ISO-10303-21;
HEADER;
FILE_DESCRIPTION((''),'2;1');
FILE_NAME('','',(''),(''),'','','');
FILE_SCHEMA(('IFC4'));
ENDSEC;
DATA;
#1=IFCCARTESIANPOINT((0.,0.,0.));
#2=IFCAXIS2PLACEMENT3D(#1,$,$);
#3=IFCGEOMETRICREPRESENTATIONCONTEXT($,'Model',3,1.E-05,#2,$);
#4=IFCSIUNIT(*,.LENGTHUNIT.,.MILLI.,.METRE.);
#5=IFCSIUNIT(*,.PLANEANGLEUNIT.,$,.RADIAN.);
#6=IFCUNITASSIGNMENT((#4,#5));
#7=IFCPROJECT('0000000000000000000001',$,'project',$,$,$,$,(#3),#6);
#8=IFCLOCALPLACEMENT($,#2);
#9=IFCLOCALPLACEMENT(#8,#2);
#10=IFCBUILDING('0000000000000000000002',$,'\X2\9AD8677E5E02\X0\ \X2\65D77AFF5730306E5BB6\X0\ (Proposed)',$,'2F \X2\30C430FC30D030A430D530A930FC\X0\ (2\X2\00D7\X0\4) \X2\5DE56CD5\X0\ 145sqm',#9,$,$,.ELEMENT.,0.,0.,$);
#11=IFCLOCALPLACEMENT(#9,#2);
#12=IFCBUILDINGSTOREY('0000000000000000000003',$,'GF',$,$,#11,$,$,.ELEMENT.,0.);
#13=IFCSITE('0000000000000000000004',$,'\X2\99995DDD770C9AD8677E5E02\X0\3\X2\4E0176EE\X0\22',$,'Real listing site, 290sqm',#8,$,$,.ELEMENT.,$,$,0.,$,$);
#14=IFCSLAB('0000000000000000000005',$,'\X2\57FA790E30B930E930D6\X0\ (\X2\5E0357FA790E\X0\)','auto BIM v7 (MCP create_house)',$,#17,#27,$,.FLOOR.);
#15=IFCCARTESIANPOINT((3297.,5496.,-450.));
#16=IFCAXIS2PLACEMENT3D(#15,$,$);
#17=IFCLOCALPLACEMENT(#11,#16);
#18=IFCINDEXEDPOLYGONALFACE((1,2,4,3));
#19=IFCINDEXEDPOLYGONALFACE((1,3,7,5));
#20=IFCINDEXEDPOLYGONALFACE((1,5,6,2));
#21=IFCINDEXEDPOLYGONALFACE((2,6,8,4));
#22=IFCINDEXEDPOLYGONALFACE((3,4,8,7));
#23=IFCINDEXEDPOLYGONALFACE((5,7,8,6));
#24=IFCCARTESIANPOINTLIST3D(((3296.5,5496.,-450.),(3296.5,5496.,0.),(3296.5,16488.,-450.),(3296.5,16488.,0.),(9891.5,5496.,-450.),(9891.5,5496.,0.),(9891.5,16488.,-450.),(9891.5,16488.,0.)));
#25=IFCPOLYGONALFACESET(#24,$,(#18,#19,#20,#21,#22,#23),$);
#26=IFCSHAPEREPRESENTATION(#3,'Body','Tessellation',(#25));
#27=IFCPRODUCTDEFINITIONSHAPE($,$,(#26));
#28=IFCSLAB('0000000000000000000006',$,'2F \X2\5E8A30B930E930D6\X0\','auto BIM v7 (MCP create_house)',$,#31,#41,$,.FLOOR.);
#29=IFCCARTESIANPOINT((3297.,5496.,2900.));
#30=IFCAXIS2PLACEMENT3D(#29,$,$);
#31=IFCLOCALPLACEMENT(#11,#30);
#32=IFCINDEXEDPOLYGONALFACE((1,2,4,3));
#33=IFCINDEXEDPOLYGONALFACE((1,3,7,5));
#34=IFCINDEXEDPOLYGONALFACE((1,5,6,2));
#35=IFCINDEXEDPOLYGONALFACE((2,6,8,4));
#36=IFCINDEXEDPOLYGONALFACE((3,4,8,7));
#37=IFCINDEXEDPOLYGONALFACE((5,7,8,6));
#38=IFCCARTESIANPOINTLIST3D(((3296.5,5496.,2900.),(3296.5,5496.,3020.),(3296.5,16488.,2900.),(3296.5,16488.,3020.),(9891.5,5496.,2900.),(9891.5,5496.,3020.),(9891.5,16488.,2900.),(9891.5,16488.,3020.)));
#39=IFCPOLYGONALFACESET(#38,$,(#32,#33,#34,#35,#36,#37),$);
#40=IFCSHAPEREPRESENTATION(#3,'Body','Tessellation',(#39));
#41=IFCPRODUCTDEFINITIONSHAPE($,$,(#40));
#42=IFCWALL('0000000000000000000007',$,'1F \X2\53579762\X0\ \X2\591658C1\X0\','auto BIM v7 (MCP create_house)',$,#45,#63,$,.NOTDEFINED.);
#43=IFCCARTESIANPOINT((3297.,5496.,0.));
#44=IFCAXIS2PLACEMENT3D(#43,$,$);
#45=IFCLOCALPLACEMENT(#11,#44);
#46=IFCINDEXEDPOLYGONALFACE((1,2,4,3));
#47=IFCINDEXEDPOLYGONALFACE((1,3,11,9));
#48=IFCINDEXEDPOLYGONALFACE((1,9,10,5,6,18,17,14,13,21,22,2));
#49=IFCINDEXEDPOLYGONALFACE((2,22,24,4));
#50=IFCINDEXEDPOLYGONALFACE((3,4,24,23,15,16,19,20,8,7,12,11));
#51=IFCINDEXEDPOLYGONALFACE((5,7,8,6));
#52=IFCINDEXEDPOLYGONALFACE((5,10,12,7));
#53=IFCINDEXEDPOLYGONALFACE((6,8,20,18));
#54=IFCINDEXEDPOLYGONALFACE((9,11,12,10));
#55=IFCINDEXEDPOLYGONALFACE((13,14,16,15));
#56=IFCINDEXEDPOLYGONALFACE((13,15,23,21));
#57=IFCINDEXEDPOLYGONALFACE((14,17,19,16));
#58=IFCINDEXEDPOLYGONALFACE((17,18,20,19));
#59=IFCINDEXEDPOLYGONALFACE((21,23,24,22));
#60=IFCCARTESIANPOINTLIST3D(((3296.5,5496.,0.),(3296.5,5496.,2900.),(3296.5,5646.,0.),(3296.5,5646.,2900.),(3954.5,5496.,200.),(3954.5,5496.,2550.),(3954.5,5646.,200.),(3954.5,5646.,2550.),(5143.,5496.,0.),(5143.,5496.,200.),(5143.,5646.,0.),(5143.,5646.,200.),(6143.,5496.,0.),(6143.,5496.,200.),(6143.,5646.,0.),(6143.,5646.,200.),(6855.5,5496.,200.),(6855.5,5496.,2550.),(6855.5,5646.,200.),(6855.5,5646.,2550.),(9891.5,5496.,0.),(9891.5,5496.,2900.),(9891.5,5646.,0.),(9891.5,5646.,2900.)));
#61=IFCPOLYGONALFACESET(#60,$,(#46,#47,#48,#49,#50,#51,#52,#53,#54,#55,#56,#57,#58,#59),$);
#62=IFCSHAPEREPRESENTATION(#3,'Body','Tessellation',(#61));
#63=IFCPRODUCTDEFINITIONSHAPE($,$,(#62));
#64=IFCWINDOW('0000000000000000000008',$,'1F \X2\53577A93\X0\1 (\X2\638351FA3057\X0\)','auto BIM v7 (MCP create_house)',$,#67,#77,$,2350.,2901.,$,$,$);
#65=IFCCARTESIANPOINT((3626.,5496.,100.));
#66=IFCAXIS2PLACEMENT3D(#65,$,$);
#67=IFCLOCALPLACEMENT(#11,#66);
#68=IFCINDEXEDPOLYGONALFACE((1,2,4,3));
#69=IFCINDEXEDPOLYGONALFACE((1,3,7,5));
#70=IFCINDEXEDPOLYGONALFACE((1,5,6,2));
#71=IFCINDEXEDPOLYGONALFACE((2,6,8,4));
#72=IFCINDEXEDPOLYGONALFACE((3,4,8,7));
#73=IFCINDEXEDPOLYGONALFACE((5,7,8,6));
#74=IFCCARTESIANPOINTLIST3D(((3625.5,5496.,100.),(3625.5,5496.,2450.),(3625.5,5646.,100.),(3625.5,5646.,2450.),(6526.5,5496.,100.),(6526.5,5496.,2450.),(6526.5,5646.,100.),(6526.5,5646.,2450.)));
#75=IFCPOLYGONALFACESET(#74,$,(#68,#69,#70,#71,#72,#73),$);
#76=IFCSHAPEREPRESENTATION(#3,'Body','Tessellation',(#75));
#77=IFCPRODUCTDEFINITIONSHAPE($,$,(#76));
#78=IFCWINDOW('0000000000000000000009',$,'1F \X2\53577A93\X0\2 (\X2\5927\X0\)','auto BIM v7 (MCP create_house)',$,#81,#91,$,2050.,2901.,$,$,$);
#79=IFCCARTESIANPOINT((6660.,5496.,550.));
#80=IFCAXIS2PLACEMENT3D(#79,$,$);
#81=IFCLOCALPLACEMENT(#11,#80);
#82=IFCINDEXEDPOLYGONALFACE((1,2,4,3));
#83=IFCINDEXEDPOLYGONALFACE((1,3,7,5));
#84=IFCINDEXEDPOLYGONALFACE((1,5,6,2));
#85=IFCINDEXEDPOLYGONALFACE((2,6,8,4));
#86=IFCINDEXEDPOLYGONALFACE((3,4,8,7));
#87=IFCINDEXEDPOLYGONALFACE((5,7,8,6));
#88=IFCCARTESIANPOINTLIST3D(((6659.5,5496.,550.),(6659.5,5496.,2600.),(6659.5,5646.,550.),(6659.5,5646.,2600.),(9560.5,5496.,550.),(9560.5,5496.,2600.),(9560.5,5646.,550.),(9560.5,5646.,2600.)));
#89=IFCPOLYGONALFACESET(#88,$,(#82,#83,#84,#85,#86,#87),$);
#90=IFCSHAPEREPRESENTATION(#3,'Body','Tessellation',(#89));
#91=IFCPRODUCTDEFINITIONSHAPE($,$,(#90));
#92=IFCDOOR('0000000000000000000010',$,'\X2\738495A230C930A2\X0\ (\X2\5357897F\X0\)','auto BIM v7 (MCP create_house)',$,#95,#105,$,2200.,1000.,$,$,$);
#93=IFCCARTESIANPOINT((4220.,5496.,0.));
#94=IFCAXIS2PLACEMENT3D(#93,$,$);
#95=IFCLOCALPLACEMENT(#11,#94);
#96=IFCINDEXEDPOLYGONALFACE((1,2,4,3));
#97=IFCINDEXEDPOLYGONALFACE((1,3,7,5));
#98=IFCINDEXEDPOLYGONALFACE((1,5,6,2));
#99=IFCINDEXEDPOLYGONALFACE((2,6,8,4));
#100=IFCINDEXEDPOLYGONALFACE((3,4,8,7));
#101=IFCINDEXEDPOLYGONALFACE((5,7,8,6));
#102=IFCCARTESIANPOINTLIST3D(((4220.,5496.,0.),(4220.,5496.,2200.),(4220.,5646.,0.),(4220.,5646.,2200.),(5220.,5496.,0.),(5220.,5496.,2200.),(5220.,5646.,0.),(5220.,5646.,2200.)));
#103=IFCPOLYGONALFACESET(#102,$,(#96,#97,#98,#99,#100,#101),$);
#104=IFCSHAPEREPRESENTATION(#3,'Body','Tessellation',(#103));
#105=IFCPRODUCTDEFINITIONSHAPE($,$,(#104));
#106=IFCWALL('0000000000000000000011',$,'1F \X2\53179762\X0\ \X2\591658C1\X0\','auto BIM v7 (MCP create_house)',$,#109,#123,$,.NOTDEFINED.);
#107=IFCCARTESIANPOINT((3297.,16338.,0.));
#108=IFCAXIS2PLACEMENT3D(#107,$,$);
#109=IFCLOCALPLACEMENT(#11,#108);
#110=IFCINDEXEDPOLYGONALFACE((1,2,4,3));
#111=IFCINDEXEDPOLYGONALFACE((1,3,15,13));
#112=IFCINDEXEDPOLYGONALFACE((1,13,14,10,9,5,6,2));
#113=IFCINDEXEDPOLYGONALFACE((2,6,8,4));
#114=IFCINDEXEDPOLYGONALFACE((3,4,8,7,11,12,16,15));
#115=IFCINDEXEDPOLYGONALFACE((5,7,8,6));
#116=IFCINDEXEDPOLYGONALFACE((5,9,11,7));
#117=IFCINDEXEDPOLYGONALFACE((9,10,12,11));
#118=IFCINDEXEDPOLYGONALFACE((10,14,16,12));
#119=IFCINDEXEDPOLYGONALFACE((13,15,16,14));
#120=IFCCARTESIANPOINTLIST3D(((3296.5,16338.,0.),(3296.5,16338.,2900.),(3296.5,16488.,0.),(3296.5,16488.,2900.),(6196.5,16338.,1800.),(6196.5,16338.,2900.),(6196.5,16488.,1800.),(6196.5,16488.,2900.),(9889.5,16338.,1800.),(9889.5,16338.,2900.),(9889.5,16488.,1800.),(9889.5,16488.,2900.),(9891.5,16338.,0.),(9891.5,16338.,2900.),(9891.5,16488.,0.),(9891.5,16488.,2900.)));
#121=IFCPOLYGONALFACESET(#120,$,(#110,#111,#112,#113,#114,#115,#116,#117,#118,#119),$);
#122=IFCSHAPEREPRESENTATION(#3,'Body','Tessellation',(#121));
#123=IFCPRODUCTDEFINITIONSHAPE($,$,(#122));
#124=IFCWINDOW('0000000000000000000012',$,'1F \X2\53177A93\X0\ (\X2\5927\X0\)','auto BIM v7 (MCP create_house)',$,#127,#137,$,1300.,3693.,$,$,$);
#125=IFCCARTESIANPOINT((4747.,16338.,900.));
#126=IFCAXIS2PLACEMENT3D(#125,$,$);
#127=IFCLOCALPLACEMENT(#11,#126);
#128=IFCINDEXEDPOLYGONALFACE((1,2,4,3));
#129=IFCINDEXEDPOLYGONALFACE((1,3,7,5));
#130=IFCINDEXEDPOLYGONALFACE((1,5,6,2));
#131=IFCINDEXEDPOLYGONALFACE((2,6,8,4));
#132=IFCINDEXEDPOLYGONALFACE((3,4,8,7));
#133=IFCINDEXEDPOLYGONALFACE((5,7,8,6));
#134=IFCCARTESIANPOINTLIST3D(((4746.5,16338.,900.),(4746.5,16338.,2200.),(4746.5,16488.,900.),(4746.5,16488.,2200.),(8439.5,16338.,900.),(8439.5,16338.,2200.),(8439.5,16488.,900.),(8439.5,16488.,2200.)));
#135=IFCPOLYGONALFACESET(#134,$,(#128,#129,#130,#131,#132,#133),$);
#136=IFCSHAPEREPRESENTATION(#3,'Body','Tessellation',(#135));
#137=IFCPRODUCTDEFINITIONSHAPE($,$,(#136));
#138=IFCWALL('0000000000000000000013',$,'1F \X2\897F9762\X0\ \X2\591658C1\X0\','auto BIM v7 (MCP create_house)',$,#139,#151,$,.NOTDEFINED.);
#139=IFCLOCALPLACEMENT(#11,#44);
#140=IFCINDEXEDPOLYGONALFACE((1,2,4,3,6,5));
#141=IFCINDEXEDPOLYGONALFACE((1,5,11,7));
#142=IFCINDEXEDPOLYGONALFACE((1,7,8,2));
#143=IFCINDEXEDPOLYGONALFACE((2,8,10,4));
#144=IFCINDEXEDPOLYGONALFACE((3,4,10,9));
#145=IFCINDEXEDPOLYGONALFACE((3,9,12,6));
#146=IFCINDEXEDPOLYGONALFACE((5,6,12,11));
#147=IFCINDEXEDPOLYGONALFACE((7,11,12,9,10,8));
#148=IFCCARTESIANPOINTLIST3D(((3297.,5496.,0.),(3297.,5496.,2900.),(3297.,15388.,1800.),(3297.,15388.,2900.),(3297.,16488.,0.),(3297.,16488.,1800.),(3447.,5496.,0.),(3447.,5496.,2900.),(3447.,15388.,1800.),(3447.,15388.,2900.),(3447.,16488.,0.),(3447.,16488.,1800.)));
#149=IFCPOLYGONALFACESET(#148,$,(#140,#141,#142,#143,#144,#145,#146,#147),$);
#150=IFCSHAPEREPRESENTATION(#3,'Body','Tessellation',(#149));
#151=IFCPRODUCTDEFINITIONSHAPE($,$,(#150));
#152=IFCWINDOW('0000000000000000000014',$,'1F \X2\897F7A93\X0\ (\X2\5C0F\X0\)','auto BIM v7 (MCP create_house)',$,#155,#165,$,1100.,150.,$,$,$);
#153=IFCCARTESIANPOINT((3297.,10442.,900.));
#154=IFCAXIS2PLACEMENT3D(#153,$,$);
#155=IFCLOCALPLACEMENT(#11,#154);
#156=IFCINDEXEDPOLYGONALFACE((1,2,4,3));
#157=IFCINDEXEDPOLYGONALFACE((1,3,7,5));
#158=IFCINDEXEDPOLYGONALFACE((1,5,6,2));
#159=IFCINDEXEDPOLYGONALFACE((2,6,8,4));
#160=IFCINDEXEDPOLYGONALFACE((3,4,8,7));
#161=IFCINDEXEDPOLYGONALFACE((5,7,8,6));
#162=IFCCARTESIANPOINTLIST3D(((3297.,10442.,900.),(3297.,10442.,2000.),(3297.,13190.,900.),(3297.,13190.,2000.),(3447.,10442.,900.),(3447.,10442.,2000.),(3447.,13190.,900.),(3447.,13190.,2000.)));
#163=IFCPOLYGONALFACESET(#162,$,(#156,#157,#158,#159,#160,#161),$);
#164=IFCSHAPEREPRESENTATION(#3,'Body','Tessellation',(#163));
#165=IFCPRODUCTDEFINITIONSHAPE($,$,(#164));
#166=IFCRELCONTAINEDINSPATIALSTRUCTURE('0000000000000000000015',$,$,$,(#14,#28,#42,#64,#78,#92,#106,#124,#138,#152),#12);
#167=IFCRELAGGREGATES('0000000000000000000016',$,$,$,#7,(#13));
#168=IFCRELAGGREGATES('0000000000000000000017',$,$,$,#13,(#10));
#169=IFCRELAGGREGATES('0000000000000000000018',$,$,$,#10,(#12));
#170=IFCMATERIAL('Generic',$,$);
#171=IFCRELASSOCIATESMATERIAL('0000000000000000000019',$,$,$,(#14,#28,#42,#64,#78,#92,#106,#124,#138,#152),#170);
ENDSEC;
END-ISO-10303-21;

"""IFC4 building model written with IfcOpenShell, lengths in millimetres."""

from ifc_helpers import new_model, si_unit, frame, frame_2d, origin, place, context, project, spatial, rectangle, extrude, material, element, fill, save


model = new_model("IFC4")

# Units and contexts
model_context = context("Model", 3, precision=1e-05, world=origin())
ifc_project = project(units=[si_unit("LENGTHUNIT", "METRE", prefix="MILLI"), si_unit("PLANEANGLEUNIT", "RADIAN")], contexts=[model_context])

# Site, building, storey
site_placement = place(None, origin())
site = spatial("IfcSite", under=ifc_project, at=site_placement, Name="香川県高松市3丁目22", ObjectType="Real listing site, 290sqm", CompositionType="ELEMENT", RefElevation=0.0)
building_placement = place(site_placement, origin())
building = spatial("IfcBuilding", under=site, at=building_placement, Name="高松市 旗竿地の家 (Proposed)", ObjectType="2F ツーバイフォー (2×4) 工法 145sqm", CompositionType="ELEMENT", ElevationOfRefHeight=0.0, ElevationOfTerrain=0.0)
storey_placement = place(building_placement, origin())
storey = spatial("IfcBuildingStorey", under=building, at=storey_placement, Name="GF", CompositionType="ELEMENT", Elevation=0.0)

# Slabs
ifc_material = material(Name="Generic")
slab_1_placement = place(storey_placement, frame((3297.0, 5496.0, -450.0)))
element("IfcSlab", 1, at=slab_1_placement, inside=storey, material=ifc_material, Name="基礎スラブ (布基礎)", Description="auto BIM v7 (MCP create_house)", PredefinedType="FLOOR", context=model_context, shape_type="SweptSolid", body=[
    extrude(rectangle(XDim=6595.0, YDim=10992.0, at=frame_2d((3297.0, 5496.0))), frame((3297.0, 5496.0, -450.0)), (0.0, 0.0, 1.0), 450.0),
])
slab_2_placement = place(storey_placement, frame((3297.0, 5496.0, 2900.0)))
element("IfcSlab", 2, at=slab_2_placement, inside=storey, material=ifc_material, Name="2F 床スラブ", Description="auto BIM v7 (MCP create_house)", PredefinedType="FLOOR", context=model_context, shape_type="SweptSolid", body=[
    extrude(rectangle(XDim=6595.0, YDim=10992.0, at=frame_2d((3297.0, 5496.0))), frame((3297.0, 5496.0, 2900.0)), (0.0, 0.0, 1.0), 120.0),
])

# Wall, openings, windows, door
wall_1_placement = place(storey_placement, frame((3297.0, 5496.0, 0.0)))
wall_1 = element("IfcWall", 3, at=wall_1_placement, inside=storey, material=ifc_material, Name="1F 南面 外壁", Description="auto BIM v7 (MCP create_house)", PredefinedType="NOTDEFINED", context=model_context, shape_type="SweptSolid", body=[
    extrude(rectangle(XDim=6595.0, YDim=150.0, at=frame_2d((3297.0, 75.0))), frame((3297.0, 5496.0, 0.0)), (0.0, 0.0, 1.0), 2900.0),
])
opening_1_placement = place(storey_placement, frame((3626.0, 5496.0, 100.0)))
opening_1 = element("IfcOpeningElement", 4, at=opening_1_placement, cuts=wall_1, PredefinedType="NOTDEFINED", context=model_context, shape_type="SweptSolid", body=[
    extrude(rectangle(XDim=2901.0, YDim=150.0, at=frame_2d((1450.0, 75.0))), frame((3626.0, 5496.0, 100.0)), (0.0, 0.0, 1.0), 2350.0),
])
opening_2_placement = place(storey_placement, frame((6660.0, 5496.0, 550.0)))
opening_2 = element("IfcOpeningElement", 5, at=opening_2_placement, cuts=wall_1, PredefinedType="NOTDEFINED", context=model_context, shape_type="SweptSolid", body=[
    extrude(rectangle(XDim=2901.0, YDim=150.0, at=frame_2d((1450.0, 75.0))), frame((6660.0, 5496.0, 550.0)), (0.0, 0.0, 1.0), 2050.0),
])
opening_3_placement = place(storey_placement, frame((4220.0, 5496.0, 0.0)))
opening_3 = element("IfcOpeningElement", 6, at=opening_3_placement, cuts=wall_1, PredefinedType="NOTDEFINED", context=model_context, shape_type="SweptSolid", body=[
    extrude(rectangle(XDim=1000.0, YDim=150.0, at=frame_2d((500.0, 75.0))), frame((4220.0, 5496.0, 0.0)), (0.0, 0.0, 1.0), 2200.0),
])
window_1_placement = place(storey_placement, frame((3626.0, 5496.0, 100.0)))
window_1 = element("IfcWindow", 7, at=window_1_placement, inside=storey, material=ifc_material, Name="1F 南窓1 (掃出し)", Description="auto BIM v7 (MCP create_house)", OverallHeight=2350.0, OverallWidth=2901.0, context=model_context, shape_type="SweptSolid", body=[
    extrude(rectangle(XDim=2901.0, YDim=150.0, at=frame_2d((1450.0, 75.0))), frame((3626.0, 5496.0, 100.0)), (0.0, 0.0, 1.0), 2350.0),
])
fill(opening_1, window_1)
window_2_placement = place(storey_placement, frame((6660.0, 5496.0, 550.0)))
window_2 = element("IfcWindow", 8, at=window_2_placement, inside=storey, material=ifc_material, Name="1F 南窓2 (大)", Description="auto BIM v7 (MCP create_house)", OverallHeight=2050.0, OverallWidth=2901.0, context=model_context, shape_type="SweptSolid", body=[
    extrude(rectangle(XDim=2901.0, YDim=150.0, at=frame_2d((1450.0, 75.0))), frame((6660.0, 5496.0, 550.0)), (0.0, 0.0, 1.0), 2050.0),
])
fill(opening_2, window_2)
door_placement = place(storey_placement, frame((4220.0, 5496.0, 0.0)))
door = element("IfcDoor", 9, at=door_placement, inside=storey, material=ifc_material, Name="玄関ドア (南西)", Description="auto BIM v7 (MCP create_house)", OverallHeight=2200.0, OverallWidth=1000.0, context=model_context, shape_type="SweptSolid", body=[
    extrude(rectangle(XDim=1000.0, YDim=150.0, at=frame_2d((500.0, 75.0))), frame((4220.0, 5496.0, 0.0)), (0.0, 0.0, 1.0), 2200.0),
])
fill(opening_3, door)

# Walls, openings, windows
wall_2_placement = place(storey_placement, frame((3297.0, 16338.0, 0.0)))
wall_2 = element("IfcWall", 10, at=wall_2_placement, inside=storey, material=ifc_material, Name="1F 北面 外壁", Description="auto BIM v7 (MCP create_house)", PredefinedType="NOTDEFINED", context=model_context, shape_type="SweptSolid", body=[
    extrude(rectangle(XDim=6595.0, YDim=150.0, at=frame_2d((3297.0, 75.0))), frame((3297.0, 16338.0, 0.0)), (0.0, 0.0, 1.0), 2900.0),
])
opening_4_placement = place(storey_placement, frame((4747.0, 16338.0, 900.0)))
opening_4 = element("IfcOpeningElement", 11, at=opening_4_placement, cuts=wall_2, PredefinedType="NOTDEFINED", context=model_context, shape_type="SweptSolid", body=[
    extrude(rectangle(XDim=3693.0, YDim=150.0, at=frame_2d((1846.0, 75.0))), frame((4747.0, 16338.0, 900.0)), (0.0, 0.0, 1.0), 1300.0),
])
window_3_placement = place(storey_placement, frame((4747.0, 16338.0, 900.0)))
window_3 = element("IfcWindow", 12, at=window_3_placement, inside=storey, material=ifc_material, Name="1F 北窓 (大)", Description="auto BIM v7 (MCP create_house)", OverallHeight=1300.0, OverallWidth=3693.0, context=model_context, shape_type="SweptSolid", body=[
    extrude(rectangle(XDim=3693.0, YDim=150.0, at=frame_2d((1846.0, 75.0))), frame((4747.0, 16338.0, 900.0)), (0.0, 0.0, 1.0), 1300.0),
])
fill(opening_4, window_3)
wall_3_placement = place(storey_placement, frame((3297.0, 5496.0, 0.0)))
wall_3 = element("IfcWall", 13, at=wall_3_placement, inside=storey, material=ifc_material, Name="1F 西面 外壁", Description="auto BIM v7 (MCP create_house)", PredefinedType="NOTDEFINED", context=model_context, shape_type="SweptSolid", body=[
    extrude(rectangle(XDim=150.0, YDim=10992.0, at=frame_2d((75.0, 5496.0))), frame((3297.0, 5496.0, 0.0)), (0.0, 0.0, 1.0), 2900.0),
])
opening_5_placement = place(storey_placement, frame((3297.0, 10442.0, 900.0)))
opening_5 = element("IfcOpeningElement", 14, at=opening_5_placement, cuts=wall_3, PredefinedType="NOTDEFINED", context=model_context, shape_type="SweptSolid", body=[
    extrude(rectangle(XDim=150.0, YDim=2748.0, at=frame_2d((75.0, 1374.0))), frame((3297.0, 10442.0, 900.0)), (0.0, 0.0, 1.0), 1100.0),
])
window_4_placement = place(storey_placement, frame((3297.0, 10442.0, 900.0)))
window_4 = element("IfcWindow", 15, at=window_4_placement, inside=storey, material=ifc_material, Name="1F 西窓 (小)", Description="auto BIM v7 (MCP create_house)", OverallHeight=1100.0, OverallWidth=150.0, context=model_context, shape_type="SweptSolid", body=[
    extrude(rectangle(XDim=150.0, YDim=2748.0, at=frame_2d((75.0, 1374.0))), frame((3297.0, 10442.0, 900.0)), (0.0, 0.0, 1.0), 1100.0),
])
fill(opening_5, window_4)

save(model, "model.ifc")
